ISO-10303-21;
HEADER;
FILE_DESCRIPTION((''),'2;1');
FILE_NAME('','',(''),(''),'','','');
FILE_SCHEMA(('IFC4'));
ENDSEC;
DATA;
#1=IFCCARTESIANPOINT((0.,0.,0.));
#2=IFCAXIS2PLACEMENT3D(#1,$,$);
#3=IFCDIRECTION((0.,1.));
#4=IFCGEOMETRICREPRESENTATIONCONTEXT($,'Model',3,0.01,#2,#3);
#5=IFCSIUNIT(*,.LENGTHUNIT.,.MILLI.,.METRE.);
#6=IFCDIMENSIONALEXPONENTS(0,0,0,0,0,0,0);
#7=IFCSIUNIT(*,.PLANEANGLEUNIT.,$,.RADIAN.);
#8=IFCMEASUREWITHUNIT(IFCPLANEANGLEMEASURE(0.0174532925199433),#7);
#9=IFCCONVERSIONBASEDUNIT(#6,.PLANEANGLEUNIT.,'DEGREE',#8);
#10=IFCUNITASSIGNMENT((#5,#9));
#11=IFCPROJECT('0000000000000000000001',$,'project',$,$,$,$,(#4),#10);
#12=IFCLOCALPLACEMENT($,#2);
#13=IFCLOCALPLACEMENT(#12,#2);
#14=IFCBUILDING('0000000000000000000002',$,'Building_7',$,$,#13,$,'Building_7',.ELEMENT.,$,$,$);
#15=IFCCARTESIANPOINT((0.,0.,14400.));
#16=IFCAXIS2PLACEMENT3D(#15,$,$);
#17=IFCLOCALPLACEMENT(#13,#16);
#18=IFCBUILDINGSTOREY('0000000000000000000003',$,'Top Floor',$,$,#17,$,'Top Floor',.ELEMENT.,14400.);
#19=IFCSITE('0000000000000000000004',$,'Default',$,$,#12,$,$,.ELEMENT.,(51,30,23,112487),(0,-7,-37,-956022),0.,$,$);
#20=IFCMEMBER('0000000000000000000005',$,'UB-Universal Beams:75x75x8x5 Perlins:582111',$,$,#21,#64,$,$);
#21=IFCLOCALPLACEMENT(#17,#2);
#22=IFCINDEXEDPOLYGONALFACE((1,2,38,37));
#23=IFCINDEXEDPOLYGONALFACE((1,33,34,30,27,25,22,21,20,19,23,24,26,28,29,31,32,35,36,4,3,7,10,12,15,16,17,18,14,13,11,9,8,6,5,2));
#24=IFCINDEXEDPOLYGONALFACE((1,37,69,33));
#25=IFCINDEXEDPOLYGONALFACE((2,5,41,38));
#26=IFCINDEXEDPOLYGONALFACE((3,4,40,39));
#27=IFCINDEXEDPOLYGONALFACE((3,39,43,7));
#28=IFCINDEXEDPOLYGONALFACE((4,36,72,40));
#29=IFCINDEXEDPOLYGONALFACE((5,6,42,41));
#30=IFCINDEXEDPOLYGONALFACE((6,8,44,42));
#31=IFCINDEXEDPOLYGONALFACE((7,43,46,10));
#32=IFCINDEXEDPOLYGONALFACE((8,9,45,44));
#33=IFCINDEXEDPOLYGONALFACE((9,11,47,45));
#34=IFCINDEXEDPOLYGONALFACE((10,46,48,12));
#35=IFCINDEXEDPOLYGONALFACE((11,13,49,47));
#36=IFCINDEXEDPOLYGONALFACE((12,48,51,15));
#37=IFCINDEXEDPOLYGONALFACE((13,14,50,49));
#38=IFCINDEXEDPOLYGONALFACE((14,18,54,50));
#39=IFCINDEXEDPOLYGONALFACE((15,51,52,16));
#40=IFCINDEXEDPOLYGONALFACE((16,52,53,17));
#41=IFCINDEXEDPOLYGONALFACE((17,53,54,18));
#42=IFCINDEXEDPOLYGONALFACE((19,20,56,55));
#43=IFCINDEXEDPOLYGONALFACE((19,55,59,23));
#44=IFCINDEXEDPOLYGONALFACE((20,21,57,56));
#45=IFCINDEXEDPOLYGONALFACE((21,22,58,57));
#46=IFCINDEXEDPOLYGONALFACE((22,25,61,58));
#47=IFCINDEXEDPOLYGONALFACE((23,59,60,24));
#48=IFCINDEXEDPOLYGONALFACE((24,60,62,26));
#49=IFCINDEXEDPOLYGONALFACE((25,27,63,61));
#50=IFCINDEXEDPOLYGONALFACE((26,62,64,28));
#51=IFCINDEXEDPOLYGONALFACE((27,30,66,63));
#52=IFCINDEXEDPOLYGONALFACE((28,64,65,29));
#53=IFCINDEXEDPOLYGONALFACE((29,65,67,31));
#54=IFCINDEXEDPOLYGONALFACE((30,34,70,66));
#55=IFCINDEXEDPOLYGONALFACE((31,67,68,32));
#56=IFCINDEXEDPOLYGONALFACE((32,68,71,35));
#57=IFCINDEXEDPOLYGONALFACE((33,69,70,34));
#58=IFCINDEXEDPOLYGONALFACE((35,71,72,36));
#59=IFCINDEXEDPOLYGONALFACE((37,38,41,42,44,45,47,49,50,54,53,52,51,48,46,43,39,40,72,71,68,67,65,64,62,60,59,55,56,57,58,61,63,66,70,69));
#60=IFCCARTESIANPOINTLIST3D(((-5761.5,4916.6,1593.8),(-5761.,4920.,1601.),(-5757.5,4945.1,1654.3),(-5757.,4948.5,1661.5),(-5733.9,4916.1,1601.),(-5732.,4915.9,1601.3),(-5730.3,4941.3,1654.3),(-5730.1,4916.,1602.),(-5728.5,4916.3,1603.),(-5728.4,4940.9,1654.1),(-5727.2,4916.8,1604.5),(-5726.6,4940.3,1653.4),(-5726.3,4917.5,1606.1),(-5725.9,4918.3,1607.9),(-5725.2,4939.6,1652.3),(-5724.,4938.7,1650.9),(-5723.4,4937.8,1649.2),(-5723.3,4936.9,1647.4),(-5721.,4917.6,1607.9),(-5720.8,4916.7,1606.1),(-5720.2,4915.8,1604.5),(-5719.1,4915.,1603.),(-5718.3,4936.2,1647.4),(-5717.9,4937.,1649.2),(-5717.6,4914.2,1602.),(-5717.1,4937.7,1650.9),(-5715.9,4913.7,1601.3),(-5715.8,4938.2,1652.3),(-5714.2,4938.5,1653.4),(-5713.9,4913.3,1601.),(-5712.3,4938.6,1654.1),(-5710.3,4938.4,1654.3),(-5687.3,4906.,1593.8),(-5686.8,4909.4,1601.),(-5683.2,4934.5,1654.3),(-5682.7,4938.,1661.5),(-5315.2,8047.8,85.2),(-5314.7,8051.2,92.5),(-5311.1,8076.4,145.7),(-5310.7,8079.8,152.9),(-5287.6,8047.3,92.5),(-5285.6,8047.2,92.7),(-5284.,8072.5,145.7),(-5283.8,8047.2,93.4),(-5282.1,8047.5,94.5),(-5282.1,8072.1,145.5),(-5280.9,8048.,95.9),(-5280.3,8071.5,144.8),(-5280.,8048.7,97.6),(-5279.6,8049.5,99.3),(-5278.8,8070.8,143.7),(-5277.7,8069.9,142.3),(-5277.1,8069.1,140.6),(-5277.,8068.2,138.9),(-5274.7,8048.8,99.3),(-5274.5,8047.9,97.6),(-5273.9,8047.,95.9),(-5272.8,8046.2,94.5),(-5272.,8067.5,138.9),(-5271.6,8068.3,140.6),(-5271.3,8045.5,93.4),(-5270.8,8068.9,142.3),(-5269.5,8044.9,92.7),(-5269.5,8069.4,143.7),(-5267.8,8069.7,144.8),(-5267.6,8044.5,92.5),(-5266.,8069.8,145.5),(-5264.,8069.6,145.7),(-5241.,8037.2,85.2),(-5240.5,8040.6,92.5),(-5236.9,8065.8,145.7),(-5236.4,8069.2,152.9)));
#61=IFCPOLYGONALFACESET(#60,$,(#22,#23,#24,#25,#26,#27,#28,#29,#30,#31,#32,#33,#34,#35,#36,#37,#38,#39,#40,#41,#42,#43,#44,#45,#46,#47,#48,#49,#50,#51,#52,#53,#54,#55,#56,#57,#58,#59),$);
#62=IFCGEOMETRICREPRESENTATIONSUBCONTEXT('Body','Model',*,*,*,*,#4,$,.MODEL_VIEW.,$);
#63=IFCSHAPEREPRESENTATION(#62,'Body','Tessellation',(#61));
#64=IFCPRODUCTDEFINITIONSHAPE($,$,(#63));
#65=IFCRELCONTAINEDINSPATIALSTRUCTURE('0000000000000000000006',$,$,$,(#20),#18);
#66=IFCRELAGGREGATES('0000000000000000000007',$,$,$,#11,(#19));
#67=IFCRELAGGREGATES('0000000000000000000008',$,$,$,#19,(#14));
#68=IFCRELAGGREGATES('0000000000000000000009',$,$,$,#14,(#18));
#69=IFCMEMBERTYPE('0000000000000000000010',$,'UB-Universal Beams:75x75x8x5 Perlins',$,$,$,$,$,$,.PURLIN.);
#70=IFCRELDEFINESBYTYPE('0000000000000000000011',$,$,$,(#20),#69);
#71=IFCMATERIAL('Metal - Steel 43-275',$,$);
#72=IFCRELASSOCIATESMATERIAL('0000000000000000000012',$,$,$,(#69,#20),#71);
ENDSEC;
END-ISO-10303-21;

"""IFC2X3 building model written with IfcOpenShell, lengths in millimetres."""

from ifc_helpers import new_model, entity, si_unit, converted_unit, direction, frame, frame_2d, origin, place, context, subcontext, project, spatial, polyline, circle_curve, parameter, trimmed, segment, composite_curve, outline, extrude, source, transform, mapped, material, type_object, type_shapes, element, save


model = new_model("IFC2X3")

# Units and contexts
model_context = context("Model", 3, precision=0.01, world=origin(), true_north=direction((0.0, 1.0)))
body_context = subcontext(model_context, "Body", "Model", "MODEL_VIEW")
ifc_project = project(units=[si_unit("LENGTHUNIT", "METRE", prefix="MILLI"), converted_unit("PLANEANGLEUNIT", "DEGREE", entity("IfcPlaneAngleMeasure", 0.0174532925199433), si_unit("PLANEANGLEUNIT", "RADIAN"), dimensions=[0, 0, 0, 0, 0, 0, 0])], contexts=[model_context])

# Site, building, storey
site_placement = place(None, origin())
site = spatial("IfcSite", under=ifc_project, at=site_placement, Name="Default", CompositionType="ELEMENT", RefLatitude=(51, 30, 23, 112487), RefLongitude=(0, -7, -37, -956022), RefElevation=0.0)
building_placement = place(site_placement, origin())
building = spatial("IfcBuilding", under=site, at=building_placement, Name="Building_7", LongName="Building_7", CompositionType="ELEMENT")
storey_placement = place(building_placement, frame((0.0, 0.0, 14400.0)))
storey = spatial("IfcBuildingStorey", under=building, at=storey_placement, Name="Top Floor", LongName="Top Floor", CompositionType="ELEMENT", Elevation=14400.0)

# Shared definitions
ifc_material = material(Name="Metal - Steel 43-275")

# Member
member_type_1 = type_object("IfcMemberType", Name="UB-Universal Beams:75x75x8x5 Perlins", PredefinedType="PURLIN", material=ifc_material)
shared_shape_1 = source(origin(), body_context, "Body", "SweptSolid", [
    extrude(outline(composite_curve([segment(polyline([(29.5, -37.5), (37.5, -37.5)]), True, "CONTINUOUS"), segment(polyline([(37.5, -37.5), (37.5, 37.5)]), True, "CONTINUOUS"), segment(polyline([(37.5, 37.5), (29.5, 37.5)]), True, "CONTINUOUS"), segment(polyline([(29.5, 37.5), (29.5, 10.1)]), True, "CONTINUOUS"), segment(trimmed(circle_curve(frame_2d((21.9, 10.1), x_axis=(0.0, 1.0)), 7.6), [parameter(180.0)], [parameter(270.0)], True, "PARAMETER"), False, "CONTINUOUS"), segment(polyline([(21.9, 2.5), (-21.9, 2.5)]), True, "CONTINUOUS"), segment(trimmed(circle_curve(frame_2d((-21.9, 10.1), x_axis=(0.0, 1.0)), 7.6), [parameter(90.0)], [parameter(180.0)], True, "PARAMETER"), False, "CONTINUOUS"), segment(polyline([(-29.5, 10.1), (-29.5, 37.5)]), True, "CONTINUOUS"), segment(polyline([(-29.5, 37.5), (-37.5, 37.5)]), True, "CONTINUOUS"), segment(polyline([(-37.5, 37.5), (-37.5, -37.5)]), True, "CONTINUOUS"), segment(polyline([(-37.5, -37.5), (-29.5, -37.5)]), True, "CONTINUOUS"), segment(polyline([(-29.5, -37.5), (-29.5, -10.1)]), True, "CONTINUOUS"), segment(trimmed(circle_curve(frame_2d((-21.9, -10.1), x_axis=(0.0, 1.0)), 7.6), [parameter(360.0)], [parameter(90.0)], True, "PARAMETER"), False, "CONTINUOUS"), segment(polyline([(-21.9, -2.5), (21.9, -2.5)]), True, "CONTINUOUS"), segment(trimmed(circle_curve(frame_2d((21.9, -10.1), x_axis=(0.0, 1.0)), 7.6), [parameter(270.0)], [parameter(360.0)], True, "PARAMETER"), False, "CONTINUOUS"), segment(polyline([(29.5, -10.1), (29.5, -37.5)]), True, "CONTINUOUS")], self_intersect=False)), frame((-1741.1, 0.0, 0.0), z_axis=(1.0, 0.0, 0.0), x_axis=(0.0, 0.0, -1.0)), (0.0, 0.0, 1.0), 3504.2),
])
type_shapes(member_type_1, [shared_shape_1])
member_1_placement = place(storey_placement, frame((-5500.4, 6483.1, 878.1), z_axis=(0.060749, 0.426193, 0.90259), x_axis=(0.127367, 0.893559, -0.430501)))
element("IfcMember", 1, at=member_1_placement, inside=storey, type_object=member_type_1, material=ifc_material, Name="UB-Universal Beams:75x75x8x5 Perlins:582111", context=body_context, shape_type="MappedRepresentation", body=[
    mapped(shared_shape_1, transform((0.0, 0.0, 0.0), scale=1.0)),
])

save(model, "model.ifc")
